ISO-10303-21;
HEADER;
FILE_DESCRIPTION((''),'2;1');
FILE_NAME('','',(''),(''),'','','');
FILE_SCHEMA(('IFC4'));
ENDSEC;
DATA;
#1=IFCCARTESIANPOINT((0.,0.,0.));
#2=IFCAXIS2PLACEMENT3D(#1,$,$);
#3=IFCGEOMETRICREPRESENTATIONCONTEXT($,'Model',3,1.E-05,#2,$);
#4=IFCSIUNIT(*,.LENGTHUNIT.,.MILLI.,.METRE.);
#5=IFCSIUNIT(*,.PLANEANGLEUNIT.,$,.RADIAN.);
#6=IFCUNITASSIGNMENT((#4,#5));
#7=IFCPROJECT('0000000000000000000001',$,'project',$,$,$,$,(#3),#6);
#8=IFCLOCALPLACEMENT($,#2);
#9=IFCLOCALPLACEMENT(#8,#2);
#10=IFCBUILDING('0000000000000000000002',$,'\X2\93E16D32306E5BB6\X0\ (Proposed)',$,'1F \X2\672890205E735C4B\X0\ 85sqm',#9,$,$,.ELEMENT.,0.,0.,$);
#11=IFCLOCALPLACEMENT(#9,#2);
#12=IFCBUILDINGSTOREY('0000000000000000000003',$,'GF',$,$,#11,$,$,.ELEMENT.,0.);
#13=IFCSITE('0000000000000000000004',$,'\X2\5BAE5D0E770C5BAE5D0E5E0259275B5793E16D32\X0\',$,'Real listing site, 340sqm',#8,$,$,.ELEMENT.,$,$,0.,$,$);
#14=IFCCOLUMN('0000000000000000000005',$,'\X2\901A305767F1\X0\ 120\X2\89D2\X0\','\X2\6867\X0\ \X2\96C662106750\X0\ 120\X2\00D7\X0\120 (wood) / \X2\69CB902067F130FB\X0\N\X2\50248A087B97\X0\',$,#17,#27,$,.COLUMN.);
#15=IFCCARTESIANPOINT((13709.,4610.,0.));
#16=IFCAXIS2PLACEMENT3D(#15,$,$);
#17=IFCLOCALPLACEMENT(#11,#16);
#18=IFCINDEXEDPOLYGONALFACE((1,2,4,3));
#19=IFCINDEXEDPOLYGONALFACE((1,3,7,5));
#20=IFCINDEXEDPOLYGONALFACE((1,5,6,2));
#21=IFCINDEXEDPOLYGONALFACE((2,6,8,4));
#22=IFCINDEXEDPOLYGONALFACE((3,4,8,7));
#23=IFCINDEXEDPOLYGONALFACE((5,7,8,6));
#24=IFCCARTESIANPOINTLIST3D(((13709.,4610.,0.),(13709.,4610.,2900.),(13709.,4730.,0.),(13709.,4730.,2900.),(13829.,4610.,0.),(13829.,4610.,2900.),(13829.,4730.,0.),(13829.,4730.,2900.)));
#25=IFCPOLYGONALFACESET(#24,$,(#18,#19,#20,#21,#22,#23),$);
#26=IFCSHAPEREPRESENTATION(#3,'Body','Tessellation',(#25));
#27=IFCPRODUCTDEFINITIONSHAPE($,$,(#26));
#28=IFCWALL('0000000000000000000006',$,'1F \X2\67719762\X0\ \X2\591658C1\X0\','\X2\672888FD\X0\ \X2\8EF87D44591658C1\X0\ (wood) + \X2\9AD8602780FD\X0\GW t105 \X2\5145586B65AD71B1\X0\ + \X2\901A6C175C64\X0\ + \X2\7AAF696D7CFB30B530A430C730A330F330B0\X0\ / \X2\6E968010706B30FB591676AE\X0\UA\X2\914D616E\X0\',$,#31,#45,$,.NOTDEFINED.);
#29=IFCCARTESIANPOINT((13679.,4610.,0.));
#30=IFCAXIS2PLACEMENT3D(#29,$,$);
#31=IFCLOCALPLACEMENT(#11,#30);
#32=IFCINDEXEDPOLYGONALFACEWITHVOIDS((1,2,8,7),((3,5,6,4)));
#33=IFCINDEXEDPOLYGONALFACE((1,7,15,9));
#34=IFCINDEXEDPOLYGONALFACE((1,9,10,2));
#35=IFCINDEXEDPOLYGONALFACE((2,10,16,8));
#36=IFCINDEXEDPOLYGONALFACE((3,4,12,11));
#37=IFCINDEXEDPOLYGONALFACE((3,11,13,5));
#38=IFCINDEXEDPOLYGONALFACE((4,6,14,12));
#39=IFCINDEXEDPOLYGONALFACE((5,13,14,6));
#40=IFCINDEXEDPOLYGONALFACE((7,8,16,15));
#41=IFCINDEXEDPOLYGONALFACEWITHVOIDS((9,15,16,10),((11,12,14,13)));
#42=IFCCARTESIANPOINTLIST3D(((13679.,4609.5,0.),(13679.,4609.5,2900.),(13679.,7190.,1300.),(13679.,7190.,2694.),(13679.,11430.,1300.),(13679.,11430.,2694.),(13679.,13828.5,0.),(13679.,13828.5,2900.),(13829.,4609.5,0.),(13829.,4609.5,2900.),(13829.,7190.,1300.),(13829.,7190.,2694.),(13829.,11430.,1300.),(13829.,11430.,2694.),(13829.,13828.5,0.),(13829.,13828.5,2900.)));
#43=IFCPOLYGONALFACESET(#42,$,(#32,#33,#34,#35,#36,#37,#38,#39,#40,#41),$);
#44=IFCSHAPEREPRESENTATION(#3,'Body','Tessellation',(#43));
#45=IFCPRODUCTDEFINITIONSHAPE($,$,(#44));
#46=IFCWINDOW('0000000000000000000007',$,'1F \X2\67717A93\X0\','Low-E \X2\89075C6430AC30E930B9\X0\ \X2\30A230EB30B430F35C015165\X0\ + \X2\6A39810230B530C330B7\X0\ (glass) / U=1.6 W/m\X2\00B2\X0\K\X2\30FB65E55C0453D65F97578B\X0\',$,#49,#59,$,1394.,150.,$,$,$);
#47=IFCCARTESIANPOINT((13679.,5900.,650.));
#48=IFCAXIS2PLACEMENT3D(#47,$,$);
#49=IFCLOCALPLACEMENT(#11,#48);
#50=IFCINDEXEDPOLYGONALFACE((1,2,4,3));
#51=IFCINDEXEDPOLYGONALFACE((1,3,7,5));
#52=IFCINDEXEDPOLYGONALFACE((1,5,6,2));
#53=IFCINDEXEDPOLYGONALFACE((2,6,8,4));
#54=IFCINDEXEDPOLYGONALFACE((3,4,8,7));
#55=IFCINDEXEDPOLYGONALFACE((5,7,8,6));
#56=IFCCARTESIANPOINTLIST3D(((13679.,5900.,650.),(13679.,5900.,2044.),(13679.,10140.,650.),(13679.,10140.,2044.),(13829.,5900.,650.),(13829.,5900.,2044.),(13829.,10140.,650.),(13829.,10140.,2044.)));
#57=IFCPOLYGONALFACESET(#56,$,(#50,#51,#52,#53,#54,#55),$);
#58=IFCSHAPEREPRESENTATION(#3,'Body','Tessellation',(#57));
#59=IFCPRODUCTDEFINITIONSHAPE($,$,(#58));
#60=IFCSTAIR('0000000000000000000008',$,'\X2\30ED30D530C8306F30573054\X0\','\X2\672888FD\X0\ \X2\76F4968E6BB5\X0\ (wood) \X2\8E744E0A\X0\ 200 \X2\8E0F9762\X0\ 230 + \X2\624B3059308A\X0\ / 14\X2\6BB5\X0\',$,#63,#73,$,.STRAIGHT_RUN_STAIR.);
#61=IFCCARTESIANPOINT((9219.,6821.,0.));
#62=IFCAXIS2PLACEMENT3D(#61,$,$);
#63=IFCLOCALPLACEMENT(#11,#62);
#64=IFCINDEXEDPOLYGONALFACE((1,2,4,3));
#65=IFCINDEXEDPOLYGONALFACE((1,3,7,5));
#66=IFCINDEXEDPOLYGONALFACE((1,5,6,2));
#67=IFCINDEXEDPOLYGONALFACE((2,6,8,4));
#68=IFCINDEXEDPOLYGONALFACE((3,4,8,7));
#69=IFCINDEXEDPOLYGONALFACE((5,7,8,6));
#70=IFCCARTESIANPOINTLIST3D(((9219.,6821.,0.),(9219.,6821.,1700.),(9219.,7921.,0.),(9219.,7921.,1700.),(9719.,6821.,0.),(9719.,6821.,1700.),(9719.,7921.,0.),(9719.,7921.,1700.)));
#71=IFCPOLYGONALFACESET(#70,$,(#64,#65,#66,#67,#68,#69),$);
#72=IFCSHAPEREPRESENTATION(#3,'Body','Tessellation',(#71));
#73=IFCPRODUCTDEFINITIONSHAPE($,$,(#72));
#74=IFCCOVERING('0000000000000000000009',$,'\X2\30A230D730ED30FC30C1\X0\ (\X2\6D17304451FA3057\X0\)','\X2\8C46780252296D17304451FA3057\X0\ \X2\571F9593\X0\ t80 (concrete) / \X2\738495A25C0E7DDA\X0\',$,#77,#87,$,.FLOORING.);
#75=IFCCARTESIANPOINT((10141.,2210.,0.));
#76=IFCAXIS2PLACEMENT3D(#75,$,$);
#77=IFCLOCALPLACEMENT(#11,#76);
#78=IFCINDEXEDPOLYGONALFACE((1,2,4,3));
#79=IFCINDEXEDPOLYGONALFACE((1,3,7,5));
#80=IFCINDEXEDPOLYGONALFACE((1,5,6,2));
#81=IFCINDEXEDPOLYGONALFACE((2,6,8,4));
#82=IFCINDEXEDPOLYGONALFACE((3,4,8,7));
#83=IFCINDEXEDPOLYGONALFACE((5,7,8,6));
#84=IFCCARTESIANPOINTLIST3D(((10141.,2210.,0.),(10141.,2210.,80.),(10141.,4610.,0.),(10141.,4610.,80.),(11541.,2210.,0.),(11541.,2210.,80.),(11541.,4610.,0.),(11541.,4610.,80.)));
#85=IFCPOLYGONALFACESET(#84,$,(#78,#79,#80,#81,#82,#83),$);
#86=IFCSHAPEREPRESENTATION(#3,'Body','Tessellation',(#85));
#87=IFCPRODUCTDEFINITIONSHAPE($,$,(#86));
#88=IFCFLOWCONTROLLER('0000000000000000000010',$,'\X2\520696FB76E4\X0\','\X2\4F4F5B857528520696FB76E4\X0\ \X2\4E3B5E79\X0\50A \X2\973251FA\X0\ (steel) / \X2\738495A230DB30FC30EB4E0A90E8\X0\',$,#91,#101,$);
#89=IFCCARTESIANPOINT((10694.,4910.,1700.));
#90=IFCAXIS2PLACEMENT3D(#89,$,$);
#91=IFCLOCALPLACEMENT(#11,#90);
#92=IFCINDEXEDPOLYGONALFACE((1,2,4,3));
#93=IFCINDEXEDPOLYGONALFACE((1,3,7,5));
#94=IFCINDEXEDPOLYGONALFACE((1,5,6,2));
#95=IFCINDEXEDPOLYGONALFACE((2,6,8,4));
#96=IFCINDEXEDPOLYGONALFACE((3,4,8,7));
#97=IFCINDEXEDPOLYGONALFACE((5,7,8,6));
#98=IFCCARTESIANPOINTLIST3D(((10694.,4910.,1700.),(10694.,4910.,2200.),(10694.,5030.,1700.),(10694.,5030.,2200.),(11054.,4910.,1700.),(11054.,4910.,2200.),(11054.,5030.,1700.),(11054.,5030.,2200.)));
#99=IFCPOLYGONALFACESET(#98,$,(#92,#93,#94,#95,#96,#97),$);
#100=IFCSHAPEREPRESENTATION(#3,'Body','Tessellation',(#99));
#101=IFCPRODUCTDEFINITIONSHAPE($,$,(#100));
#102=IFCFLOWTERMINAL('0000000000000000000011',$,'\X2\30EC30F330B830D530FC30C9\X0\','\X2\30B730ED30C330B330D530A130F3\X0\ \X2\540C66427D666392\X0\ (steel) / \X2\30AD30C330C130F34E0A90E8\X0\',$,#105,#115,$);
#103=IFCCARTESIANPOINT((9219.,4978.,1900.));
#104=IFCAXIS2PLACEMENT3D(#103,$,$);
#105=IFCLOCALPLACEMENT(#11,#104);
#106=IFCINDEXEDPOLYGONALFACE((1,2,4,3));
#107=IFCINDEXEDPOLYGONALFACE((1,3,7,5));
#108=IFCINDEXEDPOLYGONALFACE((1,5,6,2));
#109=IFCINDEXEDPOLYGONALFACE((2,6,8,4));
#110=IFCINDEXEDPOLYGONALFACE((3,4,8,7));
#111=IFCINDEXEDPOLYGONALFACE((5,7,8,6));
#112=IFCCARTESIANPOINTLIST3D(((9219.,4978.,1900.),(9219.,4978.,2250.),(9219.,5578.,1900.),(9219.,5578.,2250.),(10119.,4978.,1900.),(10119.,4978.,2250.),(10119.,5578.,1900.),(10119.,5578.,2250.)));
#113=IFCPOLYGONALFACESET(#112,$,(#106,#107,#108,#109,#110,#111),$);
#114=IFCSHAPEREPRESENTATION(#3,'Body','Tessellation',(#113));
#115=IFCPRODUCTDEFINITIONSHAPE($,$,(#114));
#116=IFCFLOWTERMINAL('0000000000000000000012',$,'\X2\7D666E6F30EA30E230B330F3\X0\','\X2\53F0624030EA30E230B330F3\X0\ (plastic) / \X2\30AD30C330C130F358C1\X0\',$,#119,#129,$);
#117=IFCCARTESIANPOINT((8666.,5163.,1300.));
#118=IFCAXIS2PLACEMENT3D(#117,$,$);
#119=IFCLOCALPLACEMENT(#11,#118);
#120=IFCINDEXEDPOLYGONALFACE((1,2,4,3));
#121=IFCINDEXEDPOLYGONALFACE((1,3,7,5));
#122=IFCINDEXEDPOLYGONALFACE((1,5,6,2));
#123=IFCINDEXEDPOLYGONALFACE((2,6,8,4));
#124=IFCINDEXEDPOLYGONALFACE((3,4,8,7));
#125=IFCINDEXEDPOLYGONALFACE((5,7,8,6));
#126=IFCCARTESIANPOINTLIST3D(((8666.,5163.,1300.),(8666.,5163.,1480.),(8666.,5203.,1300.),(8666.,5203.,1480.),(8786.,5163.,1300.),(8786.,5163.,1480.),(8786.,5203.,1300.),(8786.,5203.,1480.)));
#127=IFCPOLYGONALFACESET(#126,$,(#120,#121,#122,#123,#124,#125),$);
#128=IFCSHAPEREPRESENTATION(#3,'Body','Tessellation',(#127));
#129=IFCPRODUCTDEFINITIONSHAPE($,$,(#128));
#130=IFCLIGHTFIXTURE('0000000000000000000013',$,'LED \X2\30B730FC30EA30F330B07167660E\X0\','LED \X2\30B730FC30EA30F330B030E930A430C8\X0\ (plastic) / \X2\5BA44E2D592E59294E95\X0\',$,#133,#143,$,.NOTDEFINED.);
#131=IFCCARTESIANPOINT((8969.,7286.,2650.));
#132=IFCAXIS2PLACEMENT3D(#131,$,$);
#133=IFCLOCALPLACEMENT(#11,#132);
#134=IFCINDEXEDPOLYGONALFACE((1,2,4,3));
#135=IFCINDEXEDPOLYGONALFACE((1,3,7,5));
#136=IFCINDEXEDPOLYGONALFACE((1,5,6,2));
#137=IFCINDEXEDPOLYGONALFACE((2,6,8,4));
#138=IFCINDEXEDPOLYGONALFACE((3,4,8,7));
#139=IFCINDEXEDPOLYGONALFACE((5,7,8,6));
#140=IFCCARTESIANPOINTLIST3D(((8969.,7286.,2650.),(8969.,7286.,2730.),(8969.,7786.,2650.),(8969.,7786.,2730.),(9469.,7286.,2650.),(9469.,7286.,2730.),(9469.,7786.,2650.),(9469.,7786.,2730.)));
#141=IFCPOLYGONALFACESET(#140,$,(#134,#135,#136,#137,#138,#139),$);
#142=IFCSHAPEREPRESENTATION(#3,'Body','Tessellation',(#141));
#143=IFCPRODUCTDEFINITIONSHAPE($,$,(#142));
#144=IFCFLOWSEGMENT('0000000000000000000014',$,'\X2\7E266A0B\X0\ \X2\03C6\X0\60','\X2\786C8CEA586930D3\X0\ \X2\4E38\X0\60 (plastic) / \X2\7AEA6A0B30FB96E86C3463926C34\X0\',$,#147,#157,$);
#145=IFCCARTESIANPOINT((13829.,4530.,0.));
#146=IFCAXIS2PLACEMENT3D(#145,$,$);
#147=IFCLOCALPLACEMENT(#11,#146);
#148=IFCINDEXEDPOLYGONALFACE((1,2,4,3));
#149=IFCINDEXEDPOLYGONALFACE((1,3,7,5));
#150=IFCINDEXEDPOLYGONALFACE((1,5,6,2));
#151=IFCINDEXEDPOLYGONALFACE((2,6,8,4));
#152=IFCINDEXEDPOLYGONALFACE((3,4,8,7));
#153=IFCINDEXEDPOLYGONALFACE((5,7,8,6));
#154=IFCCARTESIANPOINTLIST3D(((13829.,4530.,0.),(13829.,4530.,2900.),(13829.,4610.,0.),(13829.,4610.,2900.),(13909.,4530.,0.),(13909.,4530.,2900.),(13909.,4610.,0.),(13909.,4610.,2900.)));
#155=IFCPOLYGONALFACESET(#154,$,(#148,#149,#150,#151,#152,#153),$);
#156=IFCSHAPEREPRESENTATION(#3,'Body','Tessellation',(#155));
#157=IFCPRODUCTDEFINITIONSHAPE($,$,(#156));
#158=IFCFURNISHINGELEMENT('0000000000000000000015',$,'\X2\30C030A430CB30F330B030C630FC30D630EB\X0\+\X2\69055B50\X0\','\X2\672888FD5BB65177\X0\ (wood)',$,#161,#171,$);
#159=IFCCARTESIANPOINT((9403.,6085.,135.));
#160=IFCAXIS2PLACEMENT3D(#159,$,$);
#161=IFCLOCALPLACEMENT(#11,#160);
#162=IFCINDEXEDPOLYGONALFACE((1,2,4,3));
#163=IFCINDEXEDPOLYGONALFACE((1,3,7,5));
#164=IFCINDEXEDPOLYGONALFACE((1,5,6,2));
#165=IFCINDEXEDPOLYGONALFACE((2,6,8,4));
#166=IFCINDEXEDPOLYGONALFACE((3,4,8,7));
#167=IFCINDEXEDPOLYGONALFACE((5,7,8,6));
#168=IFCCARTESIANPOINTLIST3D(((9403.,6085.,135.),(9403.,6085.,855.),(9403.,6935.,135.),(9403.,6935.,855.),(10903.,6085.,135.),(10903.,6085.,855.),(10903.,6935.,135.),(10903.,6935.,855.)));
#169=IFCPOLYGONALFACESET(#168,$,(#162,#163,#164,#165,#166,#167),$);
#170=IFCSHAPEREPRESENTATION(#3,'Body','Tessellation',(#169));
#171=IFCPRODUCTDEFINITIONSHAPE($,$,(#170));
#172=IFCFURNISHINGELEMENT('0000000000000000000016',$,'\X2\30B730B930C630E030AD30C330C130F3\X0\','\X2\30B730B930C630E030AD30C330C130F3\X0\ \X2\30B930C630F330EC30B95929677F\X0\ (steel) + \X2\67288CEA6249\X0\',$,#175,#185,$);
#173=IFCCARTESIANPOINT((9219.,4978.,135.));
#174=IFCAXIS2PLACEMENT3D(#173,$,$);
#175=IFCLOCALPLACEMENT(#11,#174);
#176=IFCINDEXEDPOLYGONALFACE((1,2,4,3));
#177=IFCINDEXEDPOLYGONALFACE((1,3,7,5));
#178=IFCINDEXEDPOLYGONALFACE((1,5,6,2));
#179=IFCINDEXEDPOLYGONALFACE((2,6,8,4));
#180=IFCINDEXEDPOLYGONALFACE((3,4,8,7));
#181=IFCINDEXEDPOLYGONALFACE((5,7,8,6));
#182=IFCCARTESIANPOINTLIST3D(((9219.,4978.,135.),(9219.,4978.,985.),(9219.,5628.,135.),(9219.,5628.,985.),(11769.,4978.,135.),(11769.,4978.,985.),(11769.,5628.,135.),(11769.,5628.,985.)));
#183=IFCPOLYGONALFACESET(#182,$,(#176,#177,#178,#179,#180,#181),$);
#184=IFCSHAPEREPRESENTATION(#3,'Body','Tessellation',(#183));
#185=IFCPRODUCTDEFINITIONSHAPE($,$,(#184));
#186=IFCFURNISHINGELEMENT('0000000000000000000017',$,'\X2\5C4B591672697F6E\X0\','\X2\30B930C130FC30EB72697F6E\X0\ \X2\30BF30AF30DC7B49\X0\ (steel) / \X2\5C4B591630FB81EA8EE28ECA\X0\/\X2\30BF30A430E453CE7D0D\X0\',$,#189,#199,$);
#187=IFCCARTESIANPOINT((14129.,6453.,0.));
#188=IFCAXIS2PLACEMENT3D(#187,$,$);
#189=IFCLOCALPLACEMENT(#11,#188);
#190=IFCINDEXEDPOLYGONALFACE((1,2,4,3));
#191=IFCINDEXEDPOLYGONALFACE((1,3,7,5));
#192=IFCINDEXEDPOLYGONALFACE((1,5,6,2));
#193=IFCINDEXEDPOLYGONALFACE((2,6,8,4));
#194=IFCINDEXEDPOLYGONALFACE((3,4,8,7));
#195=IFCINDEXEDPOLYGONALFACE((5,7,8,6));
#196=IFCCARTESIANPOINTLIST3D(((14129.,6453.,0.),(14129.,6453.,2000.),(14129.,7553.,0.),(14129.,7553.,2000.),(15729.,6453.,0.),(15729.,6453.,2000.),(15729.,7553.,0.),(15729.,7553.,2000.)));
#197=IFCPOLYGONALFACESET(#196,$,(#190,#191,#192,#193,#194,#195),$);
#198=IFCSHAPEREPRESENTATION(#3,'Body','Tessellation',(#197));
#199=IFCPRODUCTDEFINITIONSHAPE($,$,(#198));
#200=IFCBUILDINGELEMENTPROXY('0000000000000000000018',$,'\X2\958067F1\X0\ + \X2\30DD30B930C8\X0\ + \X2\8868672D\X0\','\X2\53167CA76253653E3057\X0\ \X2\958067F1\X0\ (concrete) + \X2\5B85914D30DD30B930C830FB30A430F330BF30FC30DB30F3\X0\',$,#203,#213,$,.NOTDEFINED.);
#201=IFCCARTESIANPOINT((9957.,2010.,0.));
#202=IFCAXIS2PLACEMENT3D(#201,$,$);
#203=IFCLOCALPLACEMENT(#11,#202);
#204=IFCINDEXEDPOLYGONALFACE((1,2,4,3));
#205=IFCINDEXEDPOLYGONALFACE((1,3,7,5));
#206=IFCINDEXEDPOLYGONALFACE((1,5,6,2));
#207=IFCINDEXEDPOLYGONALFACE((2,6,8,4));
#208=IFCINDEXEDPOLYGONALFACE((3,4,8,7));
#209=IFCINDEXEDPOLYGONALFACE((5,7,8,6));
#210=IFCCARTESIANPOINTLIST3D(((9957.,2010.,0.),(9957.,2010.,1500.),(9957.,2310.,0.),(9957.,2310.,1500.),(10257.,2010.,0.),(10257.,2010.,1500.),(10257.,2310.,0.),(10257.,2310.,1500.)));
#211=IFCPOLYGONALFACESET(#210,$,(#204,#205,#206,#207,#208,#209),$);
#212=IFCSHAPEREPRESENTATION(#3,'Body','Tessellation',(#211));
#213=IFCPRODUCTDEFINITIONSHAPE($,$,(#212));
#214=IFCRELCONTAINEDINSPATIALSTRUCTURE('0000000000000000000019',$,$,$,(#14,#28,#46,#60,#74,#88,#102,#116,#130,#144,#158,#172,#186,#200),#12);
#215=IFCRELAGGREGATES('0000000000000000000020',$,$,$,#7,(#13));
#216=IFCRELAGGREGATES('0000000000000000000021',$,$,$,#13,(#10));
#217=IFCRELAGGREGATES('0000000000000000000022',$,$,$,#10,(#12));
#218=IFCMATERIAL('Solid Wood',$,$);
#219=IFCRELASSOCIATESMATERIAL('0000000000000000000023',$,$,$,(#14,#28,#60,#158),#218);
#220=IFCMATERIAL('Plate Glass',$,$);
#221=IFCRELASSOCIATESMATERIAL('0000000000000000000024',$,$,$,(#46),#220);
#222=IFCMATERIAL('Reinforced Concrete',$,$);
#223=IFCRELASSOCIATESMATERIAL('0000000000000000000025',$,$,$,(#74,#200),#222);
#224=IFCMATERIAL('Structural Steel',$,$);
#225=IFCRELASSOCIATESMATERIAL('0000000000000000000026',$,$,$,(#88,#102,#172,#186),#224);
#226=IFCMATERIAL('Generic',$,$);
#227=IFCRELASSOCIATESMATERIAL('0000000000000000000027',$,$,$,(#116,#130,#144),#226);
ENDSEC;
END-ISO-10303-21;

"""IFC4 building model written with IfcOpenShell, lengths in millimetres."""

from ifc_helpers import new_model, si_unit, frame, frame_2d, origin, place, context, project, spatial, rectangle, extrude, material, element, fill, save


model = new_model("IFC4")

# Units and contexts
model_context = context("Model", 3, precision=1e-05, world=origin())
ifc_project = project(units=[si_unit("LENGTHUNIT", "METRE", prefix="MILLI"), si_unit("PLANEANGLEUNIT", "RADIAN")], contexts=[model_context])

# Site, building, storey
site_placement = place(None, origin())
site = spatial("IfcSite", under=ifc_project, at=site_placement, Name="宮崎県宮崎市大字鏡洲", ObjectType="Real listing site, 340sqm", CompositionType="ELEMENT", RefElevation=0.0)
building_placement = place(site_placement, origin())
building = spatial("IfcBuilding", under=site, at=building_placement, Name="鏡洲の家 (Proposed)", ObjectType="1F 木造平屋 85sqm", CompositionType="ELEMENT", ElevationOfRefHeight=0.0, ElevationOfTerrain=0.0)
storey_placement = place(building_placement, origin())
storey = spatial("IfcBuildingStorey", under=building, at=storey_placement, Name="GF", CompositionType="ELEMENT", Elevation=0.0)

# Column
ifc_material_1 = material(Name="Solid Wood")
column_1_placement = place(storey_placement, frame((13709.0, 4610.0, 0.0)))
element("IfcColumn", 1, at=column_1_placement, inside=storey, material=ifc_material_1, Name="通し柱 120角", Description="桧 集成材 120×120 (wood) / 構造柱・N値計算", PredefinedType="COLUMN", context=model_context, shape_type="SweptSolid", body=[
    extrude(rectangle(XDim=120.0, YDim=120.0, at=frame_2d((60.0, 60.0))), frame((13709.0, 4610.0, 0.0)), (0.0, 0.0, 1.0), 2900.0),
])

# Wall, opening, window
wall_1_placement = place(storey_placement, frame((13679.0, 4610.0, 0.0)))
wall_1 = element("IfcWall", 2, at=wall_1_placement, inside=storey, material=ifc_material_1, Name="1F 東面 外壁", Description="木製 軸組外壁 (wood) + 高性能GW t105 充填断熱 + 通気層 + 窯業系サイディング / 準耐火・外皮UA配慮", PredefinedType="NOTDEFINED", context=model_context, shape_type="SweptSolid", body=[
    extrude(rectangle(XDim=150.0, YDim=9219.0, at=frame_2d((75.0, 4609.0))), frame((13679.0, 4610.0, 0.0)), (0.0, 0.0, 1.0), 2900.0),
])
opening_placement = place(storey_placement, frame((13679.0, 5900.0, 650.0)))
opening = element("IfcOpeningElement", 3, at=opening_placement, cuts=wall_1, PredefinedType="NOTDEFINED", context=model_context, shape_type="SweptSolid", body=[
    extrude(rectangle(XDim=150.0, YDim=4240.0, at=frame_2d((75.0, 2120.0))), frame((13679.0, 5900.0, 650.0)), (0.0, 0.0, 1.0), 1394.0),
])
ifc_material_2 = material(Name="Plate Glass")
window_placement = place(storey_placement, frame((13679.0, 5900.0, 650.0)))
window = element("IfcWindow", 4, at=window_placement, inside=storey, material=ifc_material_2, Name="1F 東窓", Description="Low-E 複層ガラス アルゴン封入 + 樹脂サッシ (glass) / U=1.6 W/m²K・日射取得型", OverallHeight=1394.0, OverallWidth=150.0, context=model_context, shape_type="SweptSolid", body=[
    extrude(rectangle(XDim=150.0, YDim=4240.0, at=frame_2d((75.0, 2120.0))), frame((13679.0, 5900.0, 650.0)), (0.0, 0.0, 1.0), 1394.0),
])
fill(opening, window)

# Stair
stair_placement = place(storey_placement, frame((9219.0, 6821.0, 0.0)))
element("IfcStair", 5, at=stair_placement, inside=storey, material=ifc_material_1, Name="ロフトはしご", Description="木製 直階段 (wood) 蹴上 200 踏面 230 + 手すり / 14段", PredefinedType="STRAIGHT_RUN_STAIR", context=model_context, shape_type="SweptSolid", body=[
    extrude(rectangle(XDim=500.0, YDim=1100.0, at=frame_2d((250.0, 550.0))), frame((9219.0, 6821.0, 0.0)), (0.0, 0.0, 1.0), 1700.0),
])

# Covering
ifc_material_3 = material(Name="Reinforced Concrete")
covering_placement = place(storey_placement, frame((10141.0, 2210.0, 0.0)))
element("IfcCovering", 6, at=covering_placement, inside=storey, material=ifc_material_3, Name="アプローチ (洗い出し)", Description="豆砂利洗い出し 土間 t80 (concrete) / 玄関導線", PredefinedType="FLOORING", context=model_context, shape_type="SweptSolid", body=[
    extrude(rectangle(XDim=1400.0, YDim=2400.0, at=frame_2d((700.0, 1200.0))), frame((10141.0, 2210.0, 0.0)), (0.0, 0.0, 1.0), 80.0),
])

# Flow controller
ifc_material_4 = material(Name="Structural Steel")
flow_controller_placement = place(storey_placement, frame((10694.0, 4910.0, 1700.0)))
element("IfcFlowController", 7, at=flow_controller_placement, inside=storey, material=ifc_material_4, Name="分電盤", Description="住宅用分電盤 主幹50A 露出 (steel) / 玄関ホール上部", context=model_context, shape_type="SweptSolid", body=[
    extrude(rectangle(XDim=360.0, YDim=120.0, at=frame_2d((180.0, 60.0))), frame((10694.0, 4910.0, 1700.0)), (0.0, 0.0, 1.0), 500.0),
])

# Flow terminals
flow_terminal_1_placement = place(storey_placement, frame((9219.0, 4978.0, 1900.0)))
element("IfcFlowTerminal", 8, at=flow_terminal_1_placement, inside=storey, material=ifc_material_4, Name="レンジフード", Description="シロッコファン 同時給排 (steel) / キッチン上部", context=model_context, shape_type="SweptSolid", body=[
    extrude(rectangle(XDim=900.0, YDim=600.0, at=frame_2d((450.0, 300.0))), frame((9219.0, 4978.0, 1900.0)), (0.0, 0.0, 1.0), 350.0),
])
ifc_material_5 = material(Name="Generic")
flow_terminal_2_placement = place(storey_placement, frame((8666.0, 5163.0, 1300.0)))
element("IfcFlowTerminal", 9, at=flow_terminal_2_placement, inside=storey, material=ifc_material_5, Name="給湯リモコン", Description="台所リモコン (plastic) / キッチン壁", context=model_context, shape_type="SweptSolid", body=[
    extrude(rectangle(XDim=120.0, YDim=40.0, at=frame_2d((60.0, 20.0))), frame((8666.0, 5163.0, 1300.0)), (0.0, 0.0, 1.0), 180.0),
])

# Light fixture
light_fixture_placement = place(storey_placement, frame((8969.0, 7286.0, 2650.0)))
element("IfcLightFixture", 10, at=light_fixture_placement, inside=storey, material=ifc_material_5, Name="LED シーリング照明", Description="LED シーリングライト (plastic) / 室中央天井", PredefinedType="NOTDEFINED", context=model_context, shape_type="SweptSolid", body=[
    extrude(rectangle(XDim=500.0, YDim=500.0, at=frame_2d((250.0, 250.0))), frame((8969.0, 7286.0, 2650.0)), (0.0, 0.0, 1.0), 80.0),
])

# Flow segment
flow_segment_placement = place(storey_placement, frame((13829.0, 4530.0, 0.0)))
element("IfcFlowSegment", 11, at=flow_segment_placement, inside=storey, material=ifc_material_5, Name="縦樋 φ60", Description="硬質塩ビ 丸60 (plastic) / 竪樋・雨水排水", context=model_context, shape_type="SweptSolid", body=[
    extrude(rectangle(XDim=80.0, YDim=80.0, at=frame_2d((40.0, 40.0))), frame((13829.0, 4530.0, 0.0)), (0.0, 0.0, 1.0), 2900.0),
])

# Furnishing elements
furnishing_1_placement = place(storey_placement, frame((9403.0, 6085.0, 135.0)))
element("IfcFurnishingElement", 12, at=furnishing_1_placement, inside=storey, material=ifc_material_1, Name="ダイニングテーブル+椅子", Description="木製家具 (wood)", context=model_context, shape_type="SweptSolid", body=[
    extrude(rectangle(XDim=1500.0, YDim=850.0, at=frame_2d((750.0, 425.0))), frame((9403.0, 6085.0, 135.0)), (0.0, 0.0, 1.0), 720.0),
])
furnishing_2_placement = place(storey_placement, frame((9219.0, 4978.0, 135.0)))
element("IfcFurnishingElement", 13, at=furnishing_2_placement, inside=storey, material=ifc_material_4, Name="システムキッチン", Description="システムキッチン ステンレス天板 (steel) + 木質扉", context=model_context, shape_type="SweptSolid", body=[
    extrude(rectangle(XDim=2550.0, YDim=650.0, at=frame_2d((1275.0, 325.0))), frame((9219.0, 4978.0, 135.0)), (0.0, 0.0, 1.0), 850.0),
])
furnishing_3_placement = place(storey_placement, frame((14129.0, 6453.0, 0.0)))
element("IfcFurnishingElement", 14, at=furnishing_3_placement, inside=storey, material=ifc_material_4, Name="屋外物置", Description="スチール物置 タクボ等 (steel) / 屋外・自転車/タイヤ収納", context=model_context, shape_type="SweptSolid", body=[
    extrude(rectangle(XDim=1600.0, YDim=1100.0, at=frame_2d((800.0, 550.0))), frame((14129.0, 6453.0, 0.0)), (0.0, 0.0, 1.0), 2000.0),
])

# Building element proxy
proxy_placement = place(storey_placement, frame((9957.0, 2010.0, 0.0)))
element("IfcBuildingElementProxy", 15, at=proxy_placement, inside=storey, material=ifc_material_3, Name="門柱 + ポスト + 表札", Description="化粧打放し 門柱 (concrete) + 宅配ポスト・インターホン", PredefinedType="NOTDEFINED", context=model_context, shape_type="SweptSolid", body=[
    extrude(rectangle(XDim=300.0, YDim=300.0, at=frame_2d((150.0, 150.0))), frame((9957.0, 2010.0, 0.0)), (0.0, 0.0, 1.0), 1500.0),
])

save(model, "model.ifc")
